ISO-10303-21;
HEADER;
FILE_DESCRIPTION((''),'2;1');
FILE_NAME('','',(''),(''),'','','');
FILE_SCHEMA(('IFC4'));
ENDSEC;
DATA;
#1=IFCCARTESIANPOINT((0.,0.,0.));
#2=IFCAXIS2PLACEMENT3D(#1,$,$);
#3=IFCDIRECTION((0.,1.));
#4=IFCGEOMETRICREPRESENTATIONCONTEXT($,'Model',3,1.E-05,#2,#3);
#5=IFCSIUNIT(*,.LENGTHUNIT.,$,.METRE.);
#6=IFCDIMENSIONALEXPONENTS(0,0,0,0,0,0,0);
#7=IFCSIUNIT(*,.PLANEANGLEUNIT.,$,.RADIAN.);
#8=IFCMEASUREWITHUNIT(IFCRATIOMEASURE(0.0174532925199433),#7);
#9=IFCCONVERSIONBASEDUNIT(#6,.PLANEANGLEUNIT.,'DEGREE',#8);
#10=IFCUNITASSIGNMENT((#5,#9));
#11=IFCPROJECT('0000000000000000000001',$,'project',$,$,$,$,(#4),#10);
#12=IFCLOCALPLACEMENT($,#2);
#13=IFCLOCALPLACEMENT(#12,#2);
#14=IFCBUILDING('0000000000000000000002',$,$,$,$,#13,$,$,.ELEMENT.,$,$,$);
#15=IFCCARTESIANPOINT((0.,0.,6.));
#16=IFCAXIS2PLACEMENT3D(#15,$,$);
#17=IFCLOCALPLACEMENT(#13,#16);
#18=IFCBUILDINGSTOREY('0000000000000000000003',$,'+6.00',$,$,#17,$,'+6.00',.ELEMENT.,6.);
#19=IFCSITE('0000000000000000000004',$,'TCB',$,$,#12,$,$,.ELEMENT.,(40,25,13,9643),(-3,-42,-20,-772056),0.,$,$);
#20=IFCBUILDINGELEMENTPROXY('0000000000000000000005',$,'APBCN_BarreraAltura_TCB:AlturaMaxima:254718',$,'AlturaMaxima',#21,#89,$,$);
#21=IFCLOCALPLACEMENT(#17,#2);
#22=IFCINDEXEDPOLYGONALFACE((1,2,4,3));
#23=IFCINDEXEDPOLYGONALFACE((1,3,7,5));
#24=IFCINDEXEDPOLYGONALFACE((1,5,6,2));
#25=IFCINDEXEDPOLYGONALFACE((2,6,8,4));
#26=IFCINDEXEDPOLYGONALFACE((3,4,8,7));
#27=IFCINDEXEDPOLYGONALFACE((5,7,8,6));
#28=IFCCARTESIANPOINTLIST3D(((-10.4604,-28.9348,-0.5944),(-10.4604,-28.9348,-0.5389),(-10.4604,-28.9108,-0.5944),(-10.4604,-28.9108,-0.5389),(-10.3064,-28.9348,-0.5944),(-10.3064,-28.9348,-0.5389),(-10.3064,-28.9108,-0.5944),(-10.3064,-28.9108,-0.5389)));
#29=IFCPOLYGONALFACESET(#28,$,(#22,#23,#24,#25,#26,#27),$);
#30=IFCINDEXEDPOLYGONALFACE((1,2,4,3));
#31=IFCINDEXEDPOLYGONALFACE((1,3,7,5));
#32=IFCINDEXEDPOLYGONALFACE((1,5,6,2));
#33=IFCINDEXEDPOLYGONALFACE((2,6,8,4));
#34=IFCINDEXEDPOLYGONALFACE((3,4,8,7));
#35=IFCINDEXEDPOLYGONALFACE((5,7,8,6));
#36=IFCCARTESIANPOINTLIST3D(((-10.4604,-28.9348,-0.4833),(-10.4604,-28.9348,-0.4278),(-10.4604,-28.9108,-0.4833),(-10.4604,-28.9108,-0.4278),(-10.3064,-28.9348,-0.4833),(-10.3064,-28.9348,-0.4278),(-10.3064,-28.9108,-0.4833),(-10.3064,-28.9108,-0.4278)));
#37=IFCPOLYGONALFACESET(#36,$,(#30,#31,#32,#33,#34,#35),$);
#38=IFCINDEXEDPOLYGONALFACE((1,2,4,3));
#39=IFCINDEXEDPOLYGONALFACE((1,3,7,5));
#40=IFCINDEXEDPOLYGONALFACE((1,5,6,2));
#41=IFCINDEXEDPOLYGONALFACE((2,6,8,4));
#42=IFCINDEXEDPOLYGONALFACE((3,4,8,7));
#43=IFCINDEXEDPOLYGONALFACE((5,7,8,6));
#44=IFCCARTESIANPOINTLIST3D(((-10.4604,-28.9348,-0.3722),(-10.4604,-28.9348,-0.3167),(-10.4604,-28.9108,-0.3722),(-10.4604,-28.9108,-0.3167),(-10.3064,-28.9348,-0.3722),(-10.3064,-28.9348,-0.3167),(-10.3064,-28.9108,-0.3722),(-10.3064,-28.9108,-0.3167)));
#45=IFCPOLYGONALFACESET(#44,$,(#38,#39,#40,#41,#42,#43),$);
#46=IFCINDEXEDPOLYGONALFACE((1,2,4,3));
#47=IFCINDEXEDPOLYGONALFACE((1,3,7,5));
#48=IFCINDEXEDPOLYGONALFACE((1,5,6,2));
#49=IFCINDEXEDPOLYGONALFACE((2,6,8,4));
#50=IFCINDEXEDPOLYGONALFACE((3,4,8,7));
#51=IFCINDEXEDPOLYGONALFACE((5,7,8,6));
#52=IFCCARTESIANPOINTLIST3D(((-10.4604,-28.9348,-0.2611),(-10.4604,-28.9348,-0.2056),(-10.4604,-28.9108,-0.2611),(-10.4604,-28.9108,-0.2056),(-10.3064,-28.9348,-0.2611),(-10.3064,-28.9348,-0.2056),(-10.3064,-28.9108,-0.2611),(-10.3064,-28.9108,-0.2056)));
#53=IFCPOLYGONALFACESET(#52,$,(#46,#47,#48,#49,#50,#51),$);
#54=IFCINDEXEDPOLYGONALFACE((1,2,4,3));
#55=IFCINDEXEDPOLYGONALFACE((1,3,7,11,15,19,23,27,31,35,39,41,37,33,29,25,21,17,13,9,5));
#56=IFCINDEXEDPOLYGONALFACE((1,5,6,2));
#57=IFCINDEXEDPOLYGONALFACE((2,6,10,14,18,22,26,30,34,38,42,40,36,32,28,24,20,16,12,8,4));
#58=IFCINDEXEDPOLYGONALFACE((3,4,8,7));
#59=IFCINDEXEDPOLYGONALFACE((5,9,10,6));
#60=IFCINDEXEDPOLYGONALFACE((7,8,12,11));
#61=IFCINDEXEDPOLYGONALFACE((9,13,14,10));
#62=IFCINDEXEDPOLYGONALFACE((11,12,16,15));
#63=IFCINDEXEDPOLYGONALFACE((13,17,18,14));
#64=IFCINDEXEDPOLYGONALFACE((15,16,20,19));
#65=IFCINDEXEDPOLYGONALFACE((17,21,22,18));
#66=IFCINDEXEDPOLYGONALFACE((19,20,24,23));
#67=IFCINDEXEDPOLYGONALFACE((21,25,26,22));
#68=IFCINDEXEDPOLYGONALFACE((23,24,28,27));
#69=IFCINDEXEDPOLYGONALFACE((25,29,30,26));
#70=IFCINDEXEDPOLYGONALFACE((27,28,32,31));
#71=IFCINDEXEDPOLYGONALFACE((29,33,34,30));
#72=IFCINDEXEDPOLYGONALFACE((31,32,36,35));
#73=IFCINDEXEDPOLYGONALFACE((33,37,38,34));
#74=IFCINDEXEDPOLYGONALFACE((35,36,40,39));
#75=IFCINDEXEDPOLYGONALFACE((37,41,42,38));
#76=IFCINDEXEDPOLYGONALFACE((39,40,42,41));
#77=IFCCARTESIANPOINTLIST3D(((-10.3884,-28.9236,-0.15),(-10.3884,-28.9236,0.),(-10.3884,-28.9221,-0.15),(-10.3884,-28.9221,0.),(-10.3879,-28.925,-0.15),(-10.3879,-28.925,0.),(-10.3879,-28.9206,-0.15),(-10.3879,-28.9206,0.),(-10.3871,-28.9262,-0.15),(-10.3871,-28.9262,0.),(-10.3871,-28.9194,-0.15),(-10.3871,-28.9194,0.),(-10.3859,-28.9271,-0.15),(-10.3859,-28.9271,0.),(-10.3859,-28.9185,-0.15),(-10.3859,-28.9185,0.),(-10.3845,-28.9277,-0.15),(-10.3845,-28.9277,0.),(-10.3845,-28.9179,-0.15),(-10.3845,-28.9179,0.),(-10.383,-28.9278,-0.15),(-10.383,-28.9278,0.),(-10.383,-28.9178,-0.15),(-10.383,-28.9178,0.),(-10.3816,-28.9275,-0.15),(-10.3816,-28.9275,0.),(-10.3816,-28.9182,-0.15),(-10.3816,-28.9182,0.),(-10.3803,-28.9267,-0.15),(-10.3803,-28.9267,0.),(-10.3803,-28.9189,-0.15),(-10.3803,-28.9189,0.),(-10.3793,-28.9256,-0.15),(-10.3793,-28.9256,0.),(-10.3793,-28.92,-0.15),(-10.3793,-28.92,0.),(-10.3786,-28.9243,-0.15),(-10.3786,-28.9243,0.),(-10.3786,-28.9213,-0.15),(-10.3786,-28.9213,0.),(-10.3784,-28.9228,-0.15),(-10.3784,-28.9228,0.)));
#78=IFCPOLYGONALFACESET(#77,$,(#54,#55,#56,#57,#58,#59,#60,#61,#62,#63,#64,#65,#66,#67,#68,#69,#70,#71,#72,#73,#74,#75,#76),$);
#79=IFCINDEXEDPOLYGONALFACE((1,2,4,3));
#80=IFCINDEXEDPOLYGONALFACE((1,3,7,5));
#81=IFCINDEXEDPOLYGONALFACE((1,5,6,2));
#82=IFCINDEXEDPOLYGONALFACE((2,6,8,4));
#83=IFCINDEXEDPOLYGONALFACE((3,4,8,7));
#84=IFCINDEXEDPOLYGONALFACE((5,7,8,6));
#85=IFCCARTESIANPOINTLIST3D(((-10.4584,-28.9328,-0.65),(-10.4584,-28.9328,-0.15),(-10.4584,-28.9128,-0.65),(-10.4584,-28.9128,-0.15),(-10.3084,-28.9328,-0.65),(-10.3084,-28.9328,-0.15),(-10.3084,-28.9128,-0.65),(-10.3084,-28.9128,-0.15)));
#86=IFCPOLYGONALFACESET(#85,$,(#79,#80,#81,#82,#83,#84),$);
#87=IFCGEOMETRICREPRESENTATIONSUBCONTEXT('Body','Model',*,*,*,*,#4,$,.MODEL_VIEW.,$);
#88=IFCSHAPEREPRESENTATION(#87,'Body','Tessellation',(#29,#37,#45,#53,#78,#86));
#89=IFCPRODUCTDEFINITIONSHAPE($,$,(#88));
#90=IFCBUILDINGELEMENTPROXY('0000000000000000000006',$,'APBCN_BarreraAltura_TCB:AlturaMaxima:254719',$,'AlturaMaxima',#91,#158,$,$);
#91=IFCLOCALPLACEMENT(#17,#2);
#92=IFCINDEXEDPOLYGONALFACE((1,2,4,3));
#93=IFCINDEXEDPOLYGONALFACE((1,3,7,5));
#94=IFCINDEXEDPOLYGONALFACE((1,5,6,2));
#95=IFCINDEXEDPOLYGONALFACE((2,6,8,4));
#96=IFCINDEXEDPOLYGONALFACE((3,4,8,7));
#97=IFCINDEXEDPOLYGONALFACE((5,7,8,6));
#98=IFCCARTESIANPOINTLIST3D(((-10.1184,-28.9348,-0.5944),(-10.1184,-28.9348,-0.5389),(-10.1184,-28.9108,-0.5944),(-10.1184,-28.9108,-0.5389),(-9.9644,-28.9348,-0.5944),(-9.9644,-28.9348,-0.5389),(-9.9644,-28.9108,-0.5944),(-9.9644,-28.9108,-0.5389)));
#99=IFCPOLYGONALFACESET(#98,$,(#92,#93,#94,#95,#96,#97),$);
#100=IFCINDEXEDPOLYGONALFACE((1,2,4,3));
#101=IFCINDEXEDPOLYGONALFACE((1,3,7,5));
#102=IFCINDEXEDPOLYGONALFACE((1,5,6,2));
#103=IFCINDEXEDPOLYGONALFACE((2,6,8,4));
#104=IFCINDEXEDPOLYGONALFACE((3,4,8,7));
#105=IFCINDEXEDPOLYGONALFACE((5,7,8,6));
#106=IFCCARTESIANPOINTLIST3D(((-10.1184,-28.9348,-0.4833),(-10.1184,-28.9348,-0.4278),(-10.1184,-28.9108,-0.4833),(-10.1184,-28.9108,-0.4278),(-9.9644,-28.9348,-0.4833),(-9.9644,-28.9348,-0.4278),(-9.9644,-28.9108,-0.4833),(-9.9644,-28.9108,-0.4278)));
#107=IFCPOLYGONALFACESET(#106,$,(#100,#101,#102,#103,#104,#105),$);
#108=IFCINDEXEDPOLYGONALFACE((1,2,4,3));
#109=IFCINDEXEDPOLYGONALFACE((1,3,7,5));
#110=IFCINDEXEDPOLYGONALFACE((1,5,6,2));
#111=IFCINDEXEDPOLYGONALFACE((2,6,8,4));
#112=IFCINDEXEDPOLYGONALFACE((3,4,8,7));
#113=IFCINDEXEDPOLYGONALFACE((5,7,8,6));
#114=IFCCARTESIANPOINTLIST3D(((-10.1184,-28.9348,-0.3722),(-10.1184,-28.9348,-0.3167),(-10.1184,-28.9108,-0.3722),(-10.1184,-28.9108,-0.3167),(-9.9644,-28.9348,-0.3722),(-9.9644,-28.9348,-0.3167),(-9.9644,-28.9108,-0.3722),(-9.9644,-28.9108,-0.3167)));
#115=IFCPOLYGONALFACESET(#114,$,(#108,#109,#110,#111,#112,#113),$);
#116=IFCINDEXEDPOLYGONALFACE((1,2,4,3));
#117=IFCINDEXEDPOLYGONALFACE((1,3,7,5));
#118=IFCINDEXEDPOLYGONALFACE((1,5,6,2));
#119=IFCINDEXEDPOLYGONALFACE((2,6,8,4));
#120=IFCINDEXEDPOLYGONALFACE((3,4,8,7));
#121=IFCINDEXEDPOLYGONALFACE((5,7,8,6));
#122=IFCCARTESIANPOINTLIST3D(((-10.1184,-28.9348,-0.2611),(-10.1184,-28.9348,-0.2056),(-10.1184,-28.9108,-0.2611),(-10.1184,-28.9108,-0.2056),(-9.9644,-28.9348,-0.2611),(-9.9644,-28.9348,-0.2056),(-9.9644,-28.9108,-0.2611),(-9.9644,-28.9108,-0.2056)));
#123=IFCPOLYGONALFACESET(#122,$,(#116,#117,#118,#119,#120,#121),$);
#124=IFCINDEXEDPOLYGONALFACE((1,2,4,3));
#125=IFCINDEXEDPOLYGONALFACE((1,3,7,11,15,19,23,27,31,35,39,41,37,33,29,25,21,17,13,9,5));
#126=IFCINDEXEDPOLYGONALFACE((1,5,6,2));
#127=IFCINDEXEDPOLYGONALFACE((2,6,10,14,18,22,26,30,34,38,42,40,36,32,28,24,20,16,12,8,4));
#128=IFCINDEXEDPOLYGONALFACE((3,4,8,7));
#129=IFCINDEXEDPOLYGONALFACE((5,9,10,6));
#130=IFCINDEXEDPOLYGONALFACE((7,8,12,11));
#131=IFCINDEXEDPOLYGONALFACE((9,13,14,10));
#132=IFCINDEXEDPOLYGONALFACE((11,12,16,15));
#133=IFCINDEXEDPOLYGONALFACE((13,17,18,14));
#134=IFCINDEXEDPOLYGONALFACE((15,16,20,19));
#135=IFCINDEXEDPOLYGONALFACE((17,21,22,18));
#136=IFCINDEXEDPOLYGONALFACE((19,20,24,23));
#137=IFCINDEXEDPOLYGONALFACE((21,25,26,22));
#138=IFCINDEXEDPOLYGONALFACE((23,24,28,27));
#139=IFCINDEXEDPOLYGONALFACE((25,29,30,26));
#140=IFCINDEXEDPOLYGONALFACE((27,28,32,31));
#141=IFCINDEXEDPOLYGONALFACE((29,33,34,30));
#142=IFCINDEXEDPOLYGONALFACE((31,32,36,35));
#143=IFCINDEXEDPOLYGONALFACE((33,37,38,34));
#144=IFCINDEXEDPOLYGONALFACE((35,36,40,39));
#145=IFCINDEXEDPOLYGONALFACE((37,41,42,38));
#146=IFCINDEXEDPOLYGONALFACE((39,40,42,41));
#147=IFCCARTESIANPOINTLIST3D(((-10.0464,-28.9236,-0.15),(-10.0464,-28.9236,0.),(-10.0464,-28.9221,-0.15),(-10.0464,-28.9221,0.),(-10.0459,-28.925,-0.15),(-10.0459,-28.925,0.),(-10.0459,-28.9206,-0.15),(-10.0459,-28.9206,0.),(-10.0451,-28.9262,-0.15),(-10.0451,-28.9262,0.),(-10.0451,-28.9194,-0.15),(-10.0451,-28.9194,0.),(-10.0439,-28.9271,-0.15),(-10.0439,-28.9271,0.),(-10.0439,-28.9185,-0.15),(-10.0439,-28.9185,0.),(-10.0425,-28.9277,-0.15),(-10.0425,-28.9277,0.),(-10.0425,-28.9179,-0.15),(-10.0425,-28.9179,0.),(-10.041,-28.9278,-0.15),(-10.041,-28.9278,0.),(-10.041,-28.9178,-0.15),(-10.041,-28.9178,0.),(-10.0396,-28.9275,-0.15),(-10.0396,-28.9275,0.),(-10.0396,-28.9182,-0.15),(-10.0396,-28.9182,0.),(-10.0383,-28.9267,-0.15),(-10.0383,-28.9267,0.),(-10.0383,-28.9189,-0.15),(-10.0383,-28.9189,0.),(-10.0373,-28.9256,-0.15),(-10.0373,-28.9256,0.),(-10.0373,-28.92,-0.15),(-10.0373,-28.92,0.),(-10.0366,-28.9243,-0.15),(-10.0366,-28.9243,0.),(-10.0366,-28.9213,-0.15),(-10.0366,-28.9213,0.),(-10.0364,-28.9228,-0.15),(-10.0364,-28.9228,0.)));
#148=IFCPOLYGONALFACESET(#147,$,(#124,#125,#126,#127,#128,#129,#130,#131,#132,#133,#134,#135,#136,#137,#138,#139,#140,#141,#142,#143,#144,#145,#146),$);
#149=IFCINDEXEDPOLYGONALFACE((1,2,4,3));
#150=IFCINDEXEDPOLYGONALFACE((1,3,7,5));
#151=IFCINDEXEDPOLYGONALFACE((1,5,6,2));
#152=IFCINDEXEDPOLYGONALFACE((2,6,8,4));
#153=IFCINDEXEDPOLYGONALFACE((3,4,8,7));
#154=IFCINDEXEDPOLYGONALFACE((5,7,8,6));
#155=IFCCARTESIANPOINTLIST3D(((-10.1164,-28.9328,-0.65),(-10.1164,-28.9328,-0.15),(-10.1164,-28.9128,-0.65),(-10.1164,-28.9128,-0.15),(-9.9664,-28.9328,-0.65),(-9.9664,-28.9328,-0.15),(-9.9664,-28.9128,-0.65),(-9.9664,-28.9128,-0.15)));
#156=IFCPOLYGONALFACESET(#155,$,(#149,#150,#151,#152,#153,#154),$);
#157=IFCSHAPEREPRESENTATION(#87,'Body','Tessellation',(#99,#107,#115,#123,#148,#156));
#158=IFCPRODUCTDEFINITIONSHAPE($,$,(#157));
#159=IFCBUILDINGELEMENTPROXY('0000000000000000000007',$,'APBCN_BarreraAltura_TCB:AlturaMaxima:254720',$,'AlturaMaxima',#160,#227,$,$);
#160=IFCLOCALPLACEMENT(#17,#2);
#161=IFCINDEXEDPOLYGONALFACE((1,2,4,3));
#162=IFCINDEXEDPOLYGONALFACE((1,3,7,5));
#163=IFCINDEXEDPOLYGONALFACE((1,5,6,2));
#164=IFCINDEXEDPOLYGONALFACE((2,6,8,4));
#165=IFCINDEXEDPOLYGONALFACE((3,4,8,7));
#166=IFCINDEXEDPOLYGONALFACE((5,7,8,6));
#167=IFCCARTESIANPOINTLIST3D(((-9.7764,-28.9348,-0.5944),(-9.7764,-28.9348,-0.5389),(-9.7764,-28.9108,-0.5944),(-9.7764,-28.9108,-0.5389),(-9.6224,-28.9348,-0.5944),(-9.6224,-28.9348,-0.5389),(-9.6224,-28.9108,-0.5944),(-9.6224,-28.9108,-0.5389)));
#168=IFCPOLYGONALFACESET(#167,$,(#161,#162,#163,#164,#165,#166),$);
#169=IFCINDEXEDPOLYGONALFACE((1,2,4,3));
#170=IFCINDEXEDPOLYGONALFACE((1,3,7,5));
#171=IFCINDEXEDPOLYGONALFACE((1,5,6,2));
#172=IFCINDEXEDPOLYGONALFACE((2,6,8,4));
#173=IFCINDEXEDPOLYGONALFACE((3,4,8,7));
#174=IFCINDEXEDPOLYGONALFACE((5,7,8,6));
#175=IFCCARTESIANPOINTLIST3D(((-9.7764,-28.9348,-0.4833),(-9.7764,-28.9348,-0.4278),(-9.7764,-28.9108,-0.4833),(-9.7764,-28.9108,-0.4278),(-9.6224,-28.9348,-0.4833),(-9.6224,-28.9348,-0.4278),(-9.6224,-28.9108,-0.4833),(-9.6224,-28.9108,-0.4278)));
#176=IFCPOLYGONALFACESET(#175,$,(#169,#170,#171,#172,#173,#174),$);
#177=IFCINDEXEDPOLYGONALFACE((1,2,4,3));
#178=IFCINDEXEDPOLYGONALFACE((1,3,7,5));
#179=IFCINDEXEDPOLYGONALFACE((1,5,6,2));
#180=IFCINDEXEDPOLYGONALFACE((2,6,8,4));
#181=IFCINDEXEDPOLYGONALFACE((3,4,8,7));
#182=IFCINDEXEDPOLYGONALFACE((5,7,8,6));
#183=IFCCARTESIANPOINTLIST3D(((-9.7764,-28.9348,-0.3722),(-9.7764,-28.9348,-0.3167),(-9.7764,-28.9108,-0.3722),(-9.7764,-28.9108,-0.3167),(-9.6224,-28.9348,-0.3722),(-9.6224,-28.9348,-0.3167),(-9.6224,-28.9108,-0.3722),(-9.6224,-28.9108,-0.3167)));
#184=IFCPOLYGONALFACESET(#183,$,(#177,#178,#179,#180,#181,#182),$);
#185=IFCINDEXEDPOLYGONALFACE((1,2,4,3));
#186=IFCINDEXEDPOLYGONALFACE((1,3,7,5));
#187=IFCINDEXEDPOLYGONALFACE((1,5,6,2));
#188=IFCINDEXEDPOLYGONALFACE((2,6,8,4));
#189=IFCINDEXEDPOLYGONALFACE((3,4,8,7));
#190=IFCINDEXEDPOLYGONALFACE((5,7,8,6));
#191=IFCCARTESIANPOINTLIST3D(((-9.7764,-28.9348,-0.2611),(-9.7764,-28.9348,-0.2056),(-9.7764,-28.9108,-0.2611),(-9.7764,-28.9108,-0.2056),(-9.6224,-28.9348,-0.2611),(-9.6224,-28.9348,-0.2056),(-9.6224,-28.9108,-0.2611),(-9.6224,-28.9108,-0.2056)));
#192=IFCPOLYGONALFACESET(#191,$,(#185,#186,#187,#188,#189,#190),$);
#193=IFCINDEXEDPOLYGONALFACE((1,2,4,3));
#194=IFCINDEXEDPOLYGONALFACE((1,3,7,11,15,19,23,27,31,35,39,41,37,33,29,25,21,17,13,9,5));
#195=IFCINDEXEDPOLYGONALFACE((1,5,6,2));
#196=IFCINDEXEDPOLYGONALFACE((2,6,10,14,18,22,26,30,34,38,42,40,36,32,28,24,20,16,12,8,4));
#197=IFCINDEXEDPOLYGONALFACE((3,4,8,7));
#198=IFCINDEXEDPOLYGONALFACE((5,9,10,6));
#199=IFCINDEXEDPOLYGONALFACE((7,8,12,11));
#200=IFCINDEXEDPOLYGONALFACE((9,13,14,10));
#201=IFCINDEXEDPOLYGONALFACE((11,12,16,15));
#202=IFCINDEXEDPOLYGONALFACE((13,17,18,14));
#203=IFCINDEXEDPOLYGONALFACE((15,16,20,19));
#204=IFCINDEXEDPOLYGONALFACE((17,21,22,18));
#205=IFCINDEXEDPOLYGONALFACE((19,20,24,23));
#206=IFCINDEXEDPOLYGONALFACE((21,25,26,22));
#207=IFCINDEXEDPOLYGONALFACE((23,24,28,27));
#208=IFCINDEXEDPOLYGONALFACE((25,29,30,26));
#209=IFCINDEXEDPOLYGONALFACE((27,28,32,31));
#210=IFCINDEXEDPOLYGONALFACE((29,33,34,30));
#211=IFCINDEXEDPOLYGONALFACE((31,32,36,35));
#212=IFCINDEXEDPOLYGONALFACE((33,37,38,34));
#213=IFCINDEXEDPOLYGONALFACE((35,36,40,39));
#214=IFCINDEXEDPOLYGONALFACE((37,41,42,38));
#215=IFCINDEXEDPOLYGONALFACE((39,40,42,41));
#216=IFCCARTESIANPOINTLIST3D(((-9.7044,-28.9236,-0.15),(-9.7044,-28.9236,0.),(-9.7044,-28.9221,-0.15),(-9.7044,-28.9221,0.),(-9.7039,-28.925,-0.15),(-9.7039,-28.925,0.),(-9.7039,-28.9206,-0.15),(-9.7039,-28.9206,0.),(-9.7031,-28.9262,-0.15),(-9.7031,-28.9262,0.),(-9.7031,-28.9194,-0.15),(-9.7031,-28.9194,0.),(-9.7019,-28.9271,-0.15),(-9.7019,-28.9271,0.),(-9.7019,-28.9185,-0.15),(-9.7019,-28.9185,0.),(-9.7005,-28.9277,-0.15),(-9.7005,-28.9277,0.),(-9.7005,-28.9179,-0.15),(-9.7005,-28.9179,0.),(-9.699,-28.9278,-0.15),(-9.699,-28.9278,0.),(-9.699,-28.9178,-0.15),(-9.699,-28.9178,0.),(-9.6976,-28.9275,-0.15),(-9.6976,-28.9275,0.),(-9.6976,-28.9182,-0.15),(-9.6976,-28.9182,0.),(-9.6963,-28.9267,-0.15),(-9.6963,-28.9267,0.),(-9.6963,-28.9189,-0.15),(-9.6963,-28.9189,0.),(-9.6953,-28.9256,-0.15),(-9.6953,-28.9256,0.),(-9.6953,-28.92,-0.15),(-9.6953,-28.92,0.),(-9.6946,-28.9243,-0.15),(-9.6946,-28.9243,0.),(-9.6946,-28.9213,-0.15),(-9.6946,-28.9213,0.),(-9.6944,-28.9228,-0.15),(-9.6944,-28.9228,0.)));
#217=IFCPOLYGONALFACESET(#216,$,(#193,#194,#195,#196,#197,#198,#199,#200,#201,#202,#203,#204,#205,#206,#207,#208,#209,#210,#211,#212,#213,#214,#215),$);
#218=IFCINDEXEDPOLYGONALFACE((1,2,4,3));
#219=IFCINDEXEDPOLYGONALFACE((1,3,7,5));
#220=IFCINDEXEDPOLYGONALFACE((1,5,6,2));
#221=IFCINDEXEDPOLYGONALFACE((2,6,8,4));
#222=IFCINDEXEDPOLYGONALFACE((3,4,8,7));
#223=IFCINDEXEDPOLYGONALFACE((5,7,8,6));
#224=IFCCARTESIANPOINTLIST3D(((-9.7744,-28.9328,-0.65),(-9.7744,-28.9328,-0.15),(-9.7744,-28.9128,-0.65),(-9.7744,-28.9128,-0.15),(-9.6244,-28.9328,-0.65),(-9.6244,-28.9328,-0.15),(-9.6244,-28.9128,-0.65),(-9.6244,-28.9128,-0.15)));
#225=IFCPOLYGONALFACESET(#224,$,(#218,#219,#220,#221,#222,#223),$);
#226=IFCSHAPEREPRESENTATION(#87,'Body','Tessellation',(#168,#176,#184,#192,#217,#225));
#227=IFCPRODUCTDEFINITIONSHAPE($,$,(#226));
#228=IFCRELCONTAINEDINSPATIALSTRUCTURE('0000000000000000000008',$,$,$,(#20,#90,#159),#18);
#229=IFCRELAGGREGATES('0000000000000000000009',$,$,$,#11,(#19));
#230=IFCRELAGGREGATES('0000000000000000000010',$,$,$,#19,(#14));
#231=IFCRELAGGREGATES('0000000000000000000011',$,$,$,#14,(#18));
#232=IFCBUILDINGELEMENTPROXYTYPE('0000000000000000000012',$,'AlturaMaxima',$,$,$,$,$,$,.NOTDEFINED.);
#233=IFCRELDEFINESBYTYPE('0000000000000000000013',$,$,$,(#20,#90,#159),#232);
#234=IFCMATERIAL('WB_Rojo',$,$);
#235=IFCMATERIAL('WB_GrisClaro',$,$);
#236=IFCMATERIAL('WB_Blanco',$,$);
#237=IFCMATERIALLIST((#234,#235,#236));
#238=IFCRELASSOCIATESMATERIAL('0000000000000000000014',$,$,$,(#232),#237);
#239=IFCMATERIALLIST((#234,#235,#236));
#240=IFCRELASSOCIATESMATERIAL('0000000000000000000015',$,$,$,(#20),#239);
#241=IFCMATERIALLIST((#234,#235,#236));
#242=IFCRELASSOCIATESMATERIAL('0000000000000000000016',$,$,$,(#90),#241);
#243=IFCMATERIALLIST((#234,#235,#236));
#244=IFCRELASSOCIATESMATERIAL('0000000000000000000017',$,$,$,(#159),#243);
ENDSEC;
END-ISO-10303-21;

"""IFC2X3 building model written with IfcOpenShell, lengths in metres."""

from ifc_helpers import new_model, entity, si_unit, converted_unit, direction, frame, frame_2d, origin, origin_2d_with_axis, place, context, subcontext, project, spatial, rectangle, circle, extrude, source, transform, mapped, material, material_list, type_object, type_shapes, element, save


model = new_model("IFC2X3")

# Units and contexts
model_context = context("Model", 3, precision=1e-05, world=origin(), true_north=direction((0.0, 1.0)))
body_context = subcontext(model_context, "Body", "Model", "MODEL_VIEW")
ifc_project = project(units=[si_unit("LENGTHUNIT", "METRE"), converted_unit("PLANEANGLEUNIT", "DEGREE", entity("IfcRatioMeasure", 0.0174532925199433), si_unit("PLANEANGLEUNIT", "RADIAN"), dimensions=[0, 0, 0, 0, 0, 0, 0])], contexts=[model_context])

# Site, building, storey
site_placement = place(None, origin())
site = spatial("IfcSite", under=ifc_project, at=site_placement, Name="TCB", CompositionType="ELEMENT", RefLatitude=(40, 25, 13, 9643), RefLongitude=(-3, -42, -20, -772056), RefElevation=0.0)
building_placement = place(site_placement, origin())
building = spatial("IfcBuilding", under=site, at=building_placement, CompositionType="ELEMENT")
storey_placement = place(building_placement, frame((0.0, 0.0, 6.0)))
storey = spatial("IfcBuildingStorey", under=building, at=storey_placement, Name="+6.00", LongName="+6.00", CompositionType="ELEMENT", Elevation=6.0)

# Building element proxies
ifc_material_1 = material(Name="WB_Rojo")
ifc_material_2 = material(Name="WB_GrisClaro")
ifc_material_3 = material(Name="WB_Blanco")
ifc_material_list_1 = material_list([ifc_material_1, ifc_material_2, ifc_material_3])
building_element_proxy_type = type_object("IfcBuildingElementProxyType", Name="AlturaMaxima", PredefinedType="NOTDEFINED", material=ifc_material_list_1)
shared_shape = source(origin(), body_context, "Body", "SweptSolid", [
    extrude(rectangle(XDim=0.154, YDim=0.024, at=frame_2d((0.0, 0.0), x_axis=(1.0, 0.0))), frame((0.0, 0.0, -0.5944), z_axis=(0.0, 0.0, 1.0), x_axis=(-1.0, 0.0, 0.0)), (0.0, 0.0, 1.0), 0.0556),
    extrude(rectangle(XDim=0.154, YDim=0.024, at=frame_2d((0.0, 0.0), x_axis=(1.0, 0.0))), frame((0.0, 0.0, -0.4833), z_axis=(0.0, 0.0, 1.0), x_axis=(-1.0, 0.0, 0.0)), (0.0, 0.0, 1.0), 0.0556),
    extrude(rectangle(XDim=0.154, YDim=0.024, at=frame_2d((0.0, 0.0), x_axis=(1.0, 0.0))), frame((0.0, 0.0, -0.3722), z_axis=(0.0, 0.0, 1.0), x_axis=(-1.0, 0.0, 0.0)), (0.0, 0.0, 1.0), 0.0556),
    extrude(rectangle(XDim=0.154, YDim=0.024, at=frame_2d((0.0, 0.0), x_axis=(1.0, 0.0))), frame((0.0, 0.0, -0.2611), z_axis=(0.0, 0.0, 1.0), x_axis=(-1.0, 0.0, 0.0)), (0.0, 0.0, 1.0), 0.0556),
    extrude(circle(Radius=0.005, at=frame_2d((0.0, 0.0), x_axis=(1.0, 0.0))), frame((0.0, 0.0, -0.15)), (0.0, 0.0, 1.0), 0.15),
    extrude(rectangle(XDim=0.02, YDim=0.15, at=origin_2d_with_axis()), frame((0.0, 0.0, -0.65), z_axis=(0.0, 0.0, 1.0), x_axis=(0.0, 1.0, 0.0)), (0.0, 0.0, 1.0), 0.5),
])
type_shapes(building_element_proxy_type, [shared_shape])
ifc_material_list_2 = material_list([ifc_material_1, ifc_material_2, ifc_material_3])
proxy_1_placement = place(storey_placement, frame((-10.3834, -28.9228, 0.0)))
element("IfcBuildingElementProxy", 1, at=proxy_1_placement, inside=storey, type_object=building_element_proxy_type, material=ifc_material_list_2, Name="APBCN_BarreraAltura_TCB:AlturaMaxima:254718", ObjectType="AlturaMaxima", context=body_context, shape_type="MappedRepresentation", body=[
    mapped(shared_shape, transform((0.0, 0.0, 0.0), scale=1.0)),
])
ifc_material_list_3 = material_list([ifc_material_1, ifc_material_2, ifc_material_3])
proxy_2_placement = place(storey_placement, frame((-10.0414, -28.9228, 0.0)))
element("IfcBuildingElementProxy", 2, at=proxy_2_placement, inside=storey, type_object=building_element_proxy_type, material=ifc_material_list_3, Name="APBCN_BarreraAltura_TCB:AlturaMaxima:254719", ObjectType="AlturaMaxima", context=body_context, shape_type="MappedRepresentation", body=[
    mapped(shared_shape, transform((0.0, 0.0, 0.0), scale=1.0)),
])
ifc_material_list_4 = material_list([ifc_material_1, ifc_material_2, ifc_material_3])
proxy_3_placement = place(storey_placement, frame((-9.6994, -28.9228, 0.0)))
element("IfcBuildingElementProxy", 3, at=proxy_3_placement, inside=storey, type_object=building_element_proxy_type, material=ifc_material_list_4, Name="APBCN_BarreraAltura_TCB:AlturaMaxima:254720", ObjectType="AlturaMaxima", context=body_context, shape_type="MappedRepresentation", body=[
    mapped(shared_shape, transform((0.0, 0.0, 0.0), scale=1.0)),
])

save(model, "model.ifc")
